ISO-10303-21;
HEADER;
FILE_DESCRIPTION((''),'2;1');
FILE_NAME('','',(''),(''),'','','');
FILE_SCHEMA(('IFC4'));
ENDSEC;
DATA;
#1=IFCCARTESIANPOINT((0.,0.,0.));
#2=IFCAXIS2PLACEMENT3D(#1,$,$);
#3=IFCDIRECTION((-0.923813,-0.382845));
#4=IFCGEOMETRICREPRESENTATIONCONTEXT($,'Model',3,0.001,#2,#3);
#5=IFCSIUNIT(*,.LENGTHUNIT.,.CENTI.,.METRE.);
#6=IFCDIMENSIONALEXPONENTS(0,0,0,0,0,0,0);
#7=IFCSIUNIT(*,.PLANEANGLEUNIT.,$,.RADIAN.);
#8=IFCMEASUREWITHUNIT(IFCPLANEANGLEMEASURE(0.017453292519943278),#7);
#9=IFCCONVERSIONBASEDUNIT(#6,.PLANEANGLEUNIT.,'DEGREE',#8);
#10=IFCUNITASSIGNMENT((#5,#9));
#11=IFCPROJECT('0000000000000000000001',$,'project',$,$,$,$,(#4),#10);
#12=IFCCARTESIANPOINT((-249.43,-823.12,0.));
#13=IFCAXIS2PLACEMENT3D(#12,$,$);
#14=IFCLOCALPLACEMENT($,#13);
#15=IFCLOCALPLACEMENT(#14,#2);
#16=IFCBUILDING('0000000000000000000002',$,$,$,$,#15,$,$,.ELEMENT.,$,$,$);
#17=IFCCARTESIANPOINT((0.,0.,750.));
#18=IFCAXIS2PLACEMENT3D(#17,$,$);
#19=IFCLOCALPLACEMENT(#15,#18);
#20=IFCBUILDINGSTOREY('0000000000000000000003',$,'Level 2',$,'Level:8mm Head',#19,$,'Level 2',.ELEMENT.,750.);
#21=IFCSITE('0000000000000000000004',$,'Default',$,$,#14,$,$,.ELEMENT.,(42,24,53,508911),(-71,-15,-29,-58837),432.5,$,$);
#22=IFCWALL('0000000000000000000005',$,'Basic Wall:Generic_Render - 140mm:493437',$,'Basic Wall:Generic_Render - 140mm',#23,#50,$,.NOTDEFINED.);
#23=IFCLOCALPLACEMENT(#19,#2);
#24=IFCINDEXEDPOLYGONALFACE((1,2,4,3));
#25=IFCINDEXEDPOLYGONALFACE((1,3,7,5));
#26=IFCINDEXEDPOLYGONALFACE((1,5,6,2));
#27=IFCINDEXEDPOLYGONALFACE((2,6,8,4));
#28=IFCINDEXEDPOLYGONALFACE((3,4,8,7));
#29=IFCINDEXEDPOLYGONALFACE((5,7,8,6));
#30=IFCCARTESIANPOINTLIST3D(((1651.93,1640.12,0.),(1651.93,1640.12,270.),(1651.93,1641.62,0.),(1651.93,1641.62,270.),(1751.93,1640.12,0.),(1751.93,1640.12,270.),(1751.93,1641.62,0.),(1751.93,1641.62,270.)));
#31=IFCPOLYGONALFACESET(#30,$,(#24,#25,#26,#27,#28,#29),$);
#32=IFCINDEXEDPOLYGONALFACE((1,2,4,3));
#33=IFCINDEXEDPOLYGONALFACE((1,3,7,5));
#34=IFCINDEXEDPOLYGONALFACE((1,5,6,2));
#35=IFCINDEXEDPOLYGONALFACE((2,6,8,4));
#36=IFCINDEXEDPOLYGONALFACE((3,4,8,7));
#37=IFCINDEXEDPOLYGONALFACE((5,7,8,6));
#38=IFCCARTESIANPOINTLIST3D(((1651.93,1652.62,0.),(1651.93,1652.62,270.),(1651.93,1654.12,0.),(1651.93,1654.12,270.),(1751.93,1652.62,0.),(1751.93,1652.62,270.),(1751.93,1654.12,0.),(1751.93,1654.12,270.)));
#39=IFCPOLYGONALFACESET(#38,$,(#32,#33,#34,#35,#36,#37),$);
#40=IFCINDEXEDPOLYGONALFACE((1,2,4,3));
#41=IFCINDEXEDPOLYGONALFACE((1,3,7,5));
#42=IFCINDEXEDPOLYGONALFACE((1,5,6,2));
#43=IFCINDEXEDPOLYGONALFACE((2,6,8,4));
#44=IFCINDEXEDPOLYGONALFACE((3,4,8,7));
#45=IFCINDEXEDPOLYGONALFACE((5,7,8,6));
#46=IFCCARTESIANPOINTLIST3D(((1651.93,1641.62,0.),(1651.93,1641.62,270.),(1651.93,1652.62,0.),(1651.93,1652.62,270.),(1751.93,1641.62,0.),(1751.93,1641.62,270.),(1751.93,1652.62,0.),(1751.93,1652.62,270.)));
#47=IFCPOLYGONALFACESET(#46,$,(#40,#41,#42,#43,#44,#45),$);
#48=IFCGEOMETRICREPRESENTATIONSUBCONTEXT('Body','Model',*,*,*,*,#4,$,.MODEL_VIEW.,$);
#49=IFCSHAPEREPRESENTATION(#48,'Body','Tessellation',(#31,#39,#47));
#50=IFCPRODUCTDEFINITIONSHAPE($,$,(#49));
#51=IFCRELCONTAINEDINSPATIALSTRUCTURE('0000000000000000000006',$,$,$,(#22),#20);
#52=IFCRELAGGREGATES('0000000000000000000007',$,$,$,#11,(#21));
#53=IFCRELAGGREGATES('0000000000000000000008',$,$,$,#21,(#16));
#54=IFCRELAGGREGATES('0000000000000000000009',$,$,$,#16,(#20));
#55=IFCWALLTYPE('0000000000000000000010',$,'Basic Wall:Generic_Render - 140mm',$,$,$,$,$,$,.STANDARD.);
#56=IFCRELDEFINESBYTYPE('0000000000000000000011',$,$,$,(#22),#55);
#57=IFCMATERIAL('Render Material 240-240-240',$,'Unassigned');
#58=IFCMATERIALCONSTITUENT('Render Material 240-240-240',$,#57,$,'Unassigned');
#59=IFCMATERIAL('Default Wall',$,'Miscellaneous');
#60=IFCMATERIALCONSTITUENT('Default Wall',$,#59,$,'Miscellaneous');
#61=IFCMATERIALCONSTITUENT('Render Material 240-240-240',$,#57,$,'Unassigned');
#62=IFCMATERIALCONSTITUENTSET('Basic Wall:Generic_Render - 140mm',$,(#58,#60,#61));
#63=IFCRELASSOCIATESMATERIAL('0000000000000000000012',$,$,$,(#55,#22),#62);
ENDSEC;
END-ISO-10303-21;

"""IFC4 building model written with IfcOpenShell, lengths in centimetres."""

from ifc_helpers import new_model, entity, si_unit, converted_unit, direction, frame, origin, place, context, subcontext, project, spatial, indexed_curve, outline, extrude, material, constituent, constituent_set, type_object, element, save


model = new_model("IFC4")

# Units and contexts
model_context = context("Model", 3, precision=0.001, world=origin(), true_north=direction((-0.923813, -0.382845)))
body_context = subcontext(model_context, "Body", "Model", "MODEL_VIEW")
ifc_project = project(units=[si_unit("LENGTHUNIT", "METRE", prefix="CENTI"), converted_unit("PLANEANGLEUNIT", "DEGREE", entity("IfcPlaneAngleMeasure", 0.017453292519943278), si_unit("PLANEANGLEUNIT", "RADIAN"), dimensions=[0, 0, 0, 0, 0, 0, 0])], contexts=[model_context])

# Site, building, storey
site_placement = place(None, frame((-249.43, -823.12, 0.0)))
site = spatial("IfcSite", under=ifc_project, at=site_placement, Name="Default", CompositionType="ELEMENT", RefLatitude=(42, 24, 53, 508911), RefLongitude=(-71, -15, -29, -58837), RefElevation=432.5)
building_placement = place(site_placement, origin())
building = spatial("IfcBuilding", under=site, at=building_placement, CompositionType="ELEMENT")
storey_placement = place(building_placement, frame((0.0, 0.0, 750.0)))
storey = spatial("IfcBuildingStorey", under=building, at=storey_placement, Name="Level 2", ObjectType="Level:8mm Head", LongName="Level 2", CompositionType="ELEMENT", Elevation=750.0)

# Shared definitions
ifc_material_1 = material(Name="Render Material 240-240-240", Category="Unassigned")
ifc_material_2 = material(Name="Default Wall", Category="Miscellaneous")

# Wall
ifc_constituent_1 = constituent(ifc_material_1, Name="Render Material 240-240-240", Category="Unassigned")
ifc_constituent_2 = constituent(ifc_material_2, Name="Default Wall", Category="Miscellaneous")
ifc_constituent_3 = constituent(ifc_material_1, Name="Render Material 240-240-240", Category="Unassigned")
ifc_constituent_set_1 = constituent_set(constituents=[ifc_constituent_1, ifc_constituent_2, ifc_constituent_3], Name="Basic Wall:Generic_Render - 140mm")
wall_type_1 = type_object("IfcWallType", Name="Basic Wall:Generic_Render - 140mm", PredefinedType="STANDARD", material=ifc_constituent_set_1)
wall_1_placement = place(storey_placement, frame((1651.93, 1647.12, 0.0)))
element("IfcWall", 1, at=wall_1_placement, inside=storey, type_object=wall_type_1, material=ifc_constituent_set_1, Name="Basic Wall:Generic_Render - 140mm:493437", ObjectType="Basic Wall:Generic_Render - 140mm", PredefinedType="NOTDEFINED", context=body_context, shape_type="SweptSolid", body=[
    extrude(outline(indexed_curve([(-0.75, -50.0), (0.75, -50.0), (0.75, 50.0), (-0.75, 50.0), (-0.75, -50.0)], self_intersect=False)), frame((50.0, -6.25, 0.0), z_axis=(0.0, 0.0, 1.0), x_axis=(0.0, 1.0, 0.0)), (0.0, 0.0, 1.0), 270.0),
    extrude(outline(indexed_curve([(-0.75, -50.0), (0.75, -50.0), (0.75, 50.0), (-0.75, 50.0), (-0.75, -50.0)], self_intersect=False)), frame((50.0, 6.25, 0.0), z_axis=(0.0, 0.0, 1.0), x_axis=(0.0, -1.0, 0.0)), (0.0, 0.0, 1.0), 270.0),
    extrude(outline(indexed_curve([(-50.0, -5.5), (50.0, -5.5), (50.0, 5.5), (-50.0, 5.5), (-50.0, -5.5)], self_intersect=False)), frame((50.0, 0.0, 0.0)), (0.0, 0.0, 1.0), 270.0),
])

save(model, "model.ifc")
